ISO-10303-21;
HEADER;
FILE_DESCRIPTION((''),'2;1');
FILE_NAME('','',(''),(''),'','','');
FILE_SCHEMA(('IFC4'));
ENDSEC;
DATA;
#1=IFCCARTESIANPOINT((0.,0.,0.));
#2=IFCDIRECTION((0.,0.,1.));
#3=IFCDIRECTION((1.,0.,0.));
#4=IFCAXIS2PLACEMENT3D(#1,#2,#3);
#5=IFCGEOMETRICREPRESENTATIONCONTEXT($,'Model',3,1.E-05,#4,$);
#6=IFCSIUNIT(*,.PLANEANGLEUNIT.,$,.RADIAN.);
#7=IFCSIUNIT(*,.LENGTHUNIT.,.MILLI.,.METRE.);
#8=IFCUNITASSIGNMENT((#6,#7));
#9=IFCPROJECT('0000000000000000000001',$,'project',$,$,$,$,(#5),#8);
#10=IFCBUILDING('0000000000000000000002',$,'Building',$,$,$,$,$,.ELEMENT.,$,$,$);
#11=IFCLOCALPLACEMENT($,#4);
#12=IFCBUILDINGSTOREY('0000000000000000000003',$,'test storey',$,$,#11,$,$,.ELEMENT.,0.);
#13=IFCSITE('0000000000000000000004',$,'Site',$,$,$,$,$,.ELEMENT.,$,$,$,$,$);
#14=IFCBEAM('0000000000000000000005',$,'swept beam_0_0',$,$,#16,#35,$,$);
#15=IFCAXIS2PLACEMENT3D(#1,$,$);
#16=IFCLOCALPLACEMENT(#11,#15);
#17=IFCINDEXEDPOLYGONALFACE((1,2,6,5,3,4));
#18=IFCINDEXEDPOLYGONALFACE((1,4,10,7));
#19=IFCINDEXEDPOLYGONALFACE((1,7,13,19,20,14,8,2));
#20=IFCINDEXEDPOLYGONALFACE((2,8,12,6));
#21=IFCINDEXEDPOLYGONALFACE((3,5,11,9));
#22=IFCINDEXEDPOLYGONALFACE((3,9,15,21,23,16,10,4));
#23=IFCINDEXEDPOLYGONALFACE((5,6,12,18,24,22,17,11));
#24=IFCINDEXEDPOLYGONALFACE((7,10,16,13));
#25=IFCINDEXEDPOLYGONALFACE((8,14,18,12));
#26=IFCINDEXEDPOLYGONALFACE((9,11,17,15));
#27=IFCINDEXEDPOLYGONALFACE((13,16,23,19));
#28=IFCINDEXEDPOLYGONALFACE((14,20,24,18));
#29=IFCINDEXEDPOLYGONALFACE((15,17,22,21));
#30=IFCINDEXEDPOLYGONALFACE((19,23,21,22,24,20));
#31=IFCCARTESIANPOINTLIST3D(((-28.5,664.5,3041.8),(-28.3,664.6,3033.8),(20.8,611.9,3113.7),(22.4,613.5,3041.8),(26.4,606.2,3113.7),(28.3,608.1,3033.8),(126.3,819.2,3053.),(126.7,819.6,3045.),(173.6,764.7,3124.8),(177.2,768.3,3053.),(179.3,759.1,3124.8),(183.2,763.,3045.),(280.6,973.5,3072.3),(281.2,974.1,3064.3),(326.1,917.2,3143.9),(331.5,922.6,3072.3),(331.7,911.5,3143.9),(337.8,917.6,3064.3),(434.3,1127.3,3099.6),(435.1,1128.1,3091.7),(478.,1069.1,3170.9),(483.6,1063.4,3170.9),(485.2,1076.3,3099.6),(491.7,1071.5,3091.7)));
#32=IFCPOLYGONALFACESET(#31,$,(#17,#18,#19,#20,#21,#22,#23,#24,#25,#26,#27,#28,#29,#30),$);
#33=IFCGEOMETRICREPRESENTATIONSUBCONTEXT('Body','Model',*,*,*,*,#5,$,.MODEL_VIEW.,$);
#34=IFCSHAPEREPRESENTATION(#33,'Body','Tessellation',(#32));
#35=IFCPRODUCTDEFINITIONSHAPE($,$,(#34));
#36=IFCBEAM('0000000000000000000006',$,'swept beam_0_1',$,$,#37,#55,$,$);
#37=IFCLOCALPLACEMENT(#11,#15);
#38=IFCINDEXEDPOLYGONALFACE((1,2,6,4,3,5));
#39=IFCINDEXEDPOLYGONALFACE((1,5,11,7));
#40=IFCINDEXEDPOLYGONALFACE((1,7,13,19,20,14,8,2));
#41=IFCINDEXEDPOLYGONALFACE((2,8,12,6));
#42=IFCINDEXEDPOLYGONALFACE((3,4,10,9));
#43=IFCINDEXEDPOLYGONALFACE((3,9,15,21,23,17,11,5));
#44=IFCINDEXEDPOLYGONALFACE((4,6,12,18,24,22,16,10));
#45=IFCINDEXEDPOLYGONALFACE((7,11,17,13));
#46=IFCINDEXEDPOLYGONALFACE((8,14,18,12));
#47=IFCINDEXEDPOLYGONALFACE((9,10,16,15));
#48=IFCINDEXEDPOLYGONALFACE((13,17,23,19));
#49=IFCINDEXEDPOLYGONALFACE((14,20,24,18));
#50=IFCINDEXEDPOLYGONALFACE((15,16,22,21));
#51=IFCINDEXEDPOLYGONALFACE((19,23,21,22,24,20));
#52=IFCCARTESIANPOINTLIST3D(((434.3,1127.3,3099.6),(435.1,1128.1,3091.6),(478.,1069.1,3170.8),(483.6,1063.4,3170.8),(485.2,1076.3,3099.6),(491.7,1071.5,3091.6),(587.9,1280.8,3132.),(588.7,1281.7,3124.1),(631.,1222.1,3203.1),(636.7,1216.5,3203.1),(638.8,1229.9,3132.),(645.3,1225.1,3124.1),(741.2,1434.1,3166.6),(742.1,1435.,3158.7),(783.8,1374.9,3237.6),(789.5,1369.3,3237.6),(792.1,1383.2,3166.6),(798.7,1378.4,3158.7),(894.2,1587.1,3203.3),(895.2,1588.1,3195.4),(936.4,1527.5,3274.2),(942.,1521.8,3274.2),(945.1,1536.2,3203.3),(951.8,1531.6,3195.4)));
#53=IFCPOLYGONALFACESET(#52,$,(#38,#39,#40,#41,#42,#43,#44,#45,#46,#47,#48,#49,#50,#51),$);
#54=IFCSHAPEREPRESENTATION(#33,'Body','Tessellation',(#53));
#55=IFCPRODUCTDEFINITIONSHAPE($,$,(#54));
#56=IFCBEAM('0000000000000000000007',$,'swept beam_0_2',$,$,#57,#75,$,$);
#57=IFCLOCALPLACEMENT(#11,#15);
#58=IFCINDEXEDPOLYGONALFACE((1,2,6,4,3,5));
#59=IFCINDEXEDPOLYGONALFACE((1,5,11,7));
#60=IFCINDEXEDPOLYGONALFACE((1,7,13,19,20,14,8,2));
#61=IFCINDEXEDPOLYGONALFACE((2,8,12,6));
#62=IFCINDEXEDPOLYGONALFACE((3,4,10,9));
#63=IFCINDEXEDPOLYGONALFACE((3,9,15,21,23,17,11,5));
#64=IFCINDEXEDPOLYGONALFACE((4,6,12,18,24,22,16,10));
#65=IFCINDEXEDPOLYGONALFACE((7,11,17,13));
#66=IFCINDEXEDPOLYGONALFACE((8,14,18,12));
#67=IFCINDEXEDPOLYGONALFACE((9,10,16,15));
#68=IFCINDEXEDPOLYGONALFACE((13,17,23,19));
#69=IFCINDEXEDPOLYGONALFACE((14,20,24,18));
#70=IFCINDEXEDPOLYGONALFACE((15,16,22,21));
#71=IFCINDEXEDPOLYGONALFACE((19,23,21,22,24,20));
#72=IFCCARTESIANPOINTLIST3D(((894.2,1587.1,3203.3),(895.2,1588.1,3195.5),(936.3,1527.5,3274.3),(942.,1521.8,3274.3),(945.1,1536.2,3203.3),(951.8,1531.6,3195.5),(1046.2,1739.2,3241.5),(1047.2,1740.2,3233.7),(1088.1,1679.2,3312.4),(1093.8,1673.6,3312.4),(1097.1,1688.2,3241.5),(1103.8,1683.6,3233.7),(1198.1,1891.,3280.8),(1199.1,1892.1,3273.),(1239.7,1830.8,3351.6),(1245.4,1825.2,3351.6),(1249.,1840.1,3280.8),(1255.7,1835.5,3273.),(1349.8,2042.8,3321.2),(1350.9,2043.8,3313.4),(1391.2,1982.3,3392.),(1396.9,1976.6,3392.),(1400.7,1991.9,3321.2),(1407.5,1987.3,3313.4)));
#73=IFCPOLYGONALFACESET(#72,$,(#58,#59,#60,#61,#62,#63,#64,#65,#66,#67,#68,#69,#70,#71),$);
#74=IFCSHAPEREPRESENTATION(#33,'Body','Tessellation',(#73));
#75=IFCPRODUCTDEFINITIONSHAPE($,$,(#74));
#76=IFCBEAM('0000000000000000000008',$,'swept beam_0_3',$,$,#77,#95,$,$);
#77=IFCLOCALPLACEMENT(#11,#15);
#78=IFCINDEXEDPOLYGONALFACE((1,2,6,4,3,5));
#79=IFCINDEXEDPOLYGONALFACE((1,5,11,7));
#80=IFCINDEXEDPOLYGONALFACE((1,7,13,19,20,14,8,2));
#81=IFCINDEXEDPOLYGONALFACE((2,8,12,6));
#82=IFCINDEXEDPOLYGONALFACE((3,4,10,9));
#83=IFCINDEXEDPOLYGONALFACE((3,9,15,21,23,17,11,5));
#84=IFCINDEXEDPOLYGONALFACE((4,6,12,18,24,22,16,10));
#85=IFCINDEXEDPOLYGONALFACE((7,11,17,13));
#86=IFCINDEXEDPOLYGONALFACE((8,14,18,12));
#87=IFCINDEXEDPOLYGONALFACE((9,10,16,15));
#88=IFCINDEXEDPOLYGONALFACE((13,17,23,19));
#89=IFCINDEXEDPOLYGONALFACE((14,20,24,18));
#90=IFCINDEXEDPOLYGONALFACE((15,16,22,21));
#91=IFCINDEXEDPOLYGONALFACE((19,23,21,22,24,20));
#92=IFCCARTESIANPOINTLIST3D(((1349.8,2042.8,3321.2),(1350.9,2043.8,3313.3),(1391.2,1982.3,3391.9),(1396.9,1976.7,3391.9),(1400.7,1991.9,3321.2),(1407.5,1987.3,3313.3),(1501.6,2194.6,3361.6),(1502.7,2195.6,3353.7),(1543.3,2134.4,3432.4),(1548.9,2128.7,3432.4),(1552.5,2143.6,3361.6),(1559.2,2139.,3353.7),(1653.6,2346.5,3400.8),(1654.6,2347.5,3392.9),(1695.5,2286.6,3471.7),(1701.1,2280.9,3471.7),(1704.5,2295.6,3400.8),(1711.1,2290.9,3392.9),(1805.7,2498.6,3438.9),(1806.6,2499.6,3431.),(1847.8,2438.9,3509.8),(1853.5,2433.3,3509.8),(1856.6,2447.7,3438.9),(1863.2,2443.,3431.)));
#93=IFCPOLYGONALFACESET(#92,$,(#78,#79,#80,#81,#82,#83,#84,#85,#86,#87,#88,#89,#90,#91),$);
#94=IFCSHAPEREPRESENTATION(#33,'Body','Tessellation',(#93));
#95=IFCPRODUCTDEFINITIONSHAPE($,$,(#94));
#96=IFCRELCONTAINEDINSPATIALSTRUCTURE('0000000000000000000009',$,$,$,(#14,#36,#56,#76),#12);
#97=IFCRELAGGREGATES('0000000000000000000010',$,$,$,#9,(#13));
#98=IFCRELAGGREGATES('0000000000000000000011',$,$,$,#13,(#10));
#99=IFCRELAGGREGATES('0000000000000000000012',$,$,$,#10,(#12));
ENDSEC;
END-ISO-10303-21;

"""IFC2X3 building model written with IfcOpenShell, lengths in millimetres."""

from ifc_helpers import new_model, entity, si_unit, origin_with_axes, place, context, subcontext, project, spatial, element, save


model = new_model("IFC2X3")

# Units and contexts
model_context = context("Model", 3, precision=1e-05, world=origin_with_axes())
body_context = subcontext(model_context, "Body", "Model", "MODEL_VIEW")
ifc_project = project(units=[si_unit("PLANEANGLEUNIT", "RADIAN"), si_unit("LENGTHUNIT", "METRE", prefix="MILLI")], contexts=[model_context])

# Site, building, storey
site = spatial("IfcSite", under=ifc_project, Name="Site", CompositionType="ELEMENT")
building = spatial("IfcBuilding", under=site, Name="Building", CompositionType="ELEMENT")
storey_placement = place(None, origin_with_axes())
storey = spatial("IfcBuildingStorey", under=building, at=storey_placement, Name="test storey", CompositionType="ELEMENT", Elevation=0.0)

# Beams
beam_1_placement = place(storey_placement, origin_with_axes())
element("IfcBeam", 1, at=beam_1_placement, inside=storey, Name="swept beam_0_0", context=body_context, shape_type="SweptSolid", body=[
    entity("IfcRevolvedAreaSolid", entity("IfcArbitraryClosedProfileDef", "AREA", None, entity("IfcPolyline", [entity("IfcCartesianPoint", [-80.0, 40.0]), entity("IfcCartesianPoint", [-80.0, 32.0]), entity("IfcCartesianPoint", [-8.0, 32.0]), entity("IfcCartesianPoint", [-8.0, -40.0]), entity("IfcCartesianPoint", [0.0, -40.0]), entity("IfcCartesianPoint", [0.0, 40.0]), entity("IfcCartesianPoint", [-80.0, 40.0])])), entity("IfcAxis2Placement3D", entity("IfcCartesianPoint", [0.0, 636.4, 3033.8]), entity("IfcDirection", [-0.7067, -0.7067, -0.033]), entity("IfcDirection", [0.0233, 0.0233, -0.9995])), entity("IfcAxis1Placement", entity("IfcCartesianPoint", [-5969.6, 0.0, 0.0]), entity("IfcDirection", [0.0, 1.0, 0.0])), 0.110268),
])
beam_2_placement = place(storey_placement, origin_with_axes())
element("IfcBeam", 2, at=beam_2_placement, inside=storey, Name="swept beam_0_1", context=body_context, shape_type="SweptSolid", body=[
    entity("IfcRevolvedAreaSolid", entity("IfcArbitraryClosedProfileDef", "AREA", None, entity("IfcPolyline", [entity("IfcCartesianPoint", [-80.0, 40.0]), entity("IfcCartesianPoint", [-80.0, 32.0]), entity("IfcCartesianPoint", [-8.0, 32.0]), entity("IfcCartesianPoint", [-8.0, -40.0]), entity("IfcCartesianPoint", [0.0, -40.0]), entity("IfcCartesianPoint", [0.0, 40.0]), entity("IfcCartesianPoint", [-80.0, 40.0])])), entity("IfcAxis2Placement3D", entity("IfcCartesianPoint", [463.4, 1099.8, 3091.6]), entity("IfcDirection", [-0.6999, -0.6999, -0.1427]), entity("IfcDirection", [0.1009, 0.1009, -0.9898])), entity("IfcAxis1Placement", entity("IfcCartesianPoint", [-21961.2, 0.0, 0.0]), entity("IfcDirection", [0.0, 1.0, 0.0])), 0.030002),
])
beam_3_placement = place(storey_placement, origin_with_axes())
element("IfcBeam", 3, at=beam_3_placement, inside=storey, Name="swept beam_0_2", context=body_context, shape_type="SweptSolid", body=[
    entity("IfcRevolvedAreaSolid", entity("IfcArbitraryClosedProfileDef", "AREA", None, entity("IfcPolyline", [entity("IfcCartesianPoint", [-80.0, 40.0]), entity("IfcCartesianPoint", [-80.0, 32.0]), entity("IfcCartesianPoint", [-8.0, 32.0]), entity("IfcCartesianPoint", [-8.0, -40.0]), entity("IfcCartesianPoint", [0.0, -40.0]), entity("IfcCartesianPoint", [0.0, 40.0]), entity("IfcCartesianPoint", [-80.0, 40.0])])), entity("IfcAxis2Placement3D", entity("IfcCartesianPoint", [923.5, 1559.8, 3195.5]), entity("IfcDirection", [-0.6965, -0.6965, -0.1724]), entity("IfcDirection", [0.1219, 0.1219, -0.985])), entity("IfcAxis1Placement", entity("IfcCartesianPoint", [-42575.7, 0.0, 0.0]), entity("IfcDirection", [0.0, 1.0, 0.0])), 0.015388),
])
beam_4_placement = place(storey_placement, origin_with_axes())
element("IfcBeam", 4, at=beam_4_placement, inside=storey, Name="swept beam_0_3", context=body_context, shape_type="SweptSolid", body=[
    entity("IfcRevolvedAreaSolid", entity("IfcArbitraryClosedProfileDef", "AREA", None, entity("IfcPolyline", [entity("IfcCartesianPoint", [80.0, -40.0]), entity("IfcCartesianPoint", [80.0, -32.0]), entity("IfcCartesianPoint", [8.0, -32.0]), entity("IfcCartesianPoint", [8.0, 40.0]), entity("IfcCartesianPoint", [0.0, 40.0]), entity("IfcCartesianPoint", [0.0, -40.0]), entity("IfcCartesianPoint", [80.0, -40.0])])), entity("IfcAxis2Placement3D", entity("IfcCartesianPoint", [1379.2, 2015.5, 3313.3]), entity("IfcDirection", [-0.6946, -0.6946, -0.1875]), entity("IfcDirection", [-0.1326, -0.1326, 0.9823])), entity("IfcAxis1Placement", entity("IfcCartesianPoint", [-40846.2, 0.0, 0.0]), entity("IfcDirection", [0.0, 1.0, 0.0])), 0.01604),
])

save(model, "model.ifc")
